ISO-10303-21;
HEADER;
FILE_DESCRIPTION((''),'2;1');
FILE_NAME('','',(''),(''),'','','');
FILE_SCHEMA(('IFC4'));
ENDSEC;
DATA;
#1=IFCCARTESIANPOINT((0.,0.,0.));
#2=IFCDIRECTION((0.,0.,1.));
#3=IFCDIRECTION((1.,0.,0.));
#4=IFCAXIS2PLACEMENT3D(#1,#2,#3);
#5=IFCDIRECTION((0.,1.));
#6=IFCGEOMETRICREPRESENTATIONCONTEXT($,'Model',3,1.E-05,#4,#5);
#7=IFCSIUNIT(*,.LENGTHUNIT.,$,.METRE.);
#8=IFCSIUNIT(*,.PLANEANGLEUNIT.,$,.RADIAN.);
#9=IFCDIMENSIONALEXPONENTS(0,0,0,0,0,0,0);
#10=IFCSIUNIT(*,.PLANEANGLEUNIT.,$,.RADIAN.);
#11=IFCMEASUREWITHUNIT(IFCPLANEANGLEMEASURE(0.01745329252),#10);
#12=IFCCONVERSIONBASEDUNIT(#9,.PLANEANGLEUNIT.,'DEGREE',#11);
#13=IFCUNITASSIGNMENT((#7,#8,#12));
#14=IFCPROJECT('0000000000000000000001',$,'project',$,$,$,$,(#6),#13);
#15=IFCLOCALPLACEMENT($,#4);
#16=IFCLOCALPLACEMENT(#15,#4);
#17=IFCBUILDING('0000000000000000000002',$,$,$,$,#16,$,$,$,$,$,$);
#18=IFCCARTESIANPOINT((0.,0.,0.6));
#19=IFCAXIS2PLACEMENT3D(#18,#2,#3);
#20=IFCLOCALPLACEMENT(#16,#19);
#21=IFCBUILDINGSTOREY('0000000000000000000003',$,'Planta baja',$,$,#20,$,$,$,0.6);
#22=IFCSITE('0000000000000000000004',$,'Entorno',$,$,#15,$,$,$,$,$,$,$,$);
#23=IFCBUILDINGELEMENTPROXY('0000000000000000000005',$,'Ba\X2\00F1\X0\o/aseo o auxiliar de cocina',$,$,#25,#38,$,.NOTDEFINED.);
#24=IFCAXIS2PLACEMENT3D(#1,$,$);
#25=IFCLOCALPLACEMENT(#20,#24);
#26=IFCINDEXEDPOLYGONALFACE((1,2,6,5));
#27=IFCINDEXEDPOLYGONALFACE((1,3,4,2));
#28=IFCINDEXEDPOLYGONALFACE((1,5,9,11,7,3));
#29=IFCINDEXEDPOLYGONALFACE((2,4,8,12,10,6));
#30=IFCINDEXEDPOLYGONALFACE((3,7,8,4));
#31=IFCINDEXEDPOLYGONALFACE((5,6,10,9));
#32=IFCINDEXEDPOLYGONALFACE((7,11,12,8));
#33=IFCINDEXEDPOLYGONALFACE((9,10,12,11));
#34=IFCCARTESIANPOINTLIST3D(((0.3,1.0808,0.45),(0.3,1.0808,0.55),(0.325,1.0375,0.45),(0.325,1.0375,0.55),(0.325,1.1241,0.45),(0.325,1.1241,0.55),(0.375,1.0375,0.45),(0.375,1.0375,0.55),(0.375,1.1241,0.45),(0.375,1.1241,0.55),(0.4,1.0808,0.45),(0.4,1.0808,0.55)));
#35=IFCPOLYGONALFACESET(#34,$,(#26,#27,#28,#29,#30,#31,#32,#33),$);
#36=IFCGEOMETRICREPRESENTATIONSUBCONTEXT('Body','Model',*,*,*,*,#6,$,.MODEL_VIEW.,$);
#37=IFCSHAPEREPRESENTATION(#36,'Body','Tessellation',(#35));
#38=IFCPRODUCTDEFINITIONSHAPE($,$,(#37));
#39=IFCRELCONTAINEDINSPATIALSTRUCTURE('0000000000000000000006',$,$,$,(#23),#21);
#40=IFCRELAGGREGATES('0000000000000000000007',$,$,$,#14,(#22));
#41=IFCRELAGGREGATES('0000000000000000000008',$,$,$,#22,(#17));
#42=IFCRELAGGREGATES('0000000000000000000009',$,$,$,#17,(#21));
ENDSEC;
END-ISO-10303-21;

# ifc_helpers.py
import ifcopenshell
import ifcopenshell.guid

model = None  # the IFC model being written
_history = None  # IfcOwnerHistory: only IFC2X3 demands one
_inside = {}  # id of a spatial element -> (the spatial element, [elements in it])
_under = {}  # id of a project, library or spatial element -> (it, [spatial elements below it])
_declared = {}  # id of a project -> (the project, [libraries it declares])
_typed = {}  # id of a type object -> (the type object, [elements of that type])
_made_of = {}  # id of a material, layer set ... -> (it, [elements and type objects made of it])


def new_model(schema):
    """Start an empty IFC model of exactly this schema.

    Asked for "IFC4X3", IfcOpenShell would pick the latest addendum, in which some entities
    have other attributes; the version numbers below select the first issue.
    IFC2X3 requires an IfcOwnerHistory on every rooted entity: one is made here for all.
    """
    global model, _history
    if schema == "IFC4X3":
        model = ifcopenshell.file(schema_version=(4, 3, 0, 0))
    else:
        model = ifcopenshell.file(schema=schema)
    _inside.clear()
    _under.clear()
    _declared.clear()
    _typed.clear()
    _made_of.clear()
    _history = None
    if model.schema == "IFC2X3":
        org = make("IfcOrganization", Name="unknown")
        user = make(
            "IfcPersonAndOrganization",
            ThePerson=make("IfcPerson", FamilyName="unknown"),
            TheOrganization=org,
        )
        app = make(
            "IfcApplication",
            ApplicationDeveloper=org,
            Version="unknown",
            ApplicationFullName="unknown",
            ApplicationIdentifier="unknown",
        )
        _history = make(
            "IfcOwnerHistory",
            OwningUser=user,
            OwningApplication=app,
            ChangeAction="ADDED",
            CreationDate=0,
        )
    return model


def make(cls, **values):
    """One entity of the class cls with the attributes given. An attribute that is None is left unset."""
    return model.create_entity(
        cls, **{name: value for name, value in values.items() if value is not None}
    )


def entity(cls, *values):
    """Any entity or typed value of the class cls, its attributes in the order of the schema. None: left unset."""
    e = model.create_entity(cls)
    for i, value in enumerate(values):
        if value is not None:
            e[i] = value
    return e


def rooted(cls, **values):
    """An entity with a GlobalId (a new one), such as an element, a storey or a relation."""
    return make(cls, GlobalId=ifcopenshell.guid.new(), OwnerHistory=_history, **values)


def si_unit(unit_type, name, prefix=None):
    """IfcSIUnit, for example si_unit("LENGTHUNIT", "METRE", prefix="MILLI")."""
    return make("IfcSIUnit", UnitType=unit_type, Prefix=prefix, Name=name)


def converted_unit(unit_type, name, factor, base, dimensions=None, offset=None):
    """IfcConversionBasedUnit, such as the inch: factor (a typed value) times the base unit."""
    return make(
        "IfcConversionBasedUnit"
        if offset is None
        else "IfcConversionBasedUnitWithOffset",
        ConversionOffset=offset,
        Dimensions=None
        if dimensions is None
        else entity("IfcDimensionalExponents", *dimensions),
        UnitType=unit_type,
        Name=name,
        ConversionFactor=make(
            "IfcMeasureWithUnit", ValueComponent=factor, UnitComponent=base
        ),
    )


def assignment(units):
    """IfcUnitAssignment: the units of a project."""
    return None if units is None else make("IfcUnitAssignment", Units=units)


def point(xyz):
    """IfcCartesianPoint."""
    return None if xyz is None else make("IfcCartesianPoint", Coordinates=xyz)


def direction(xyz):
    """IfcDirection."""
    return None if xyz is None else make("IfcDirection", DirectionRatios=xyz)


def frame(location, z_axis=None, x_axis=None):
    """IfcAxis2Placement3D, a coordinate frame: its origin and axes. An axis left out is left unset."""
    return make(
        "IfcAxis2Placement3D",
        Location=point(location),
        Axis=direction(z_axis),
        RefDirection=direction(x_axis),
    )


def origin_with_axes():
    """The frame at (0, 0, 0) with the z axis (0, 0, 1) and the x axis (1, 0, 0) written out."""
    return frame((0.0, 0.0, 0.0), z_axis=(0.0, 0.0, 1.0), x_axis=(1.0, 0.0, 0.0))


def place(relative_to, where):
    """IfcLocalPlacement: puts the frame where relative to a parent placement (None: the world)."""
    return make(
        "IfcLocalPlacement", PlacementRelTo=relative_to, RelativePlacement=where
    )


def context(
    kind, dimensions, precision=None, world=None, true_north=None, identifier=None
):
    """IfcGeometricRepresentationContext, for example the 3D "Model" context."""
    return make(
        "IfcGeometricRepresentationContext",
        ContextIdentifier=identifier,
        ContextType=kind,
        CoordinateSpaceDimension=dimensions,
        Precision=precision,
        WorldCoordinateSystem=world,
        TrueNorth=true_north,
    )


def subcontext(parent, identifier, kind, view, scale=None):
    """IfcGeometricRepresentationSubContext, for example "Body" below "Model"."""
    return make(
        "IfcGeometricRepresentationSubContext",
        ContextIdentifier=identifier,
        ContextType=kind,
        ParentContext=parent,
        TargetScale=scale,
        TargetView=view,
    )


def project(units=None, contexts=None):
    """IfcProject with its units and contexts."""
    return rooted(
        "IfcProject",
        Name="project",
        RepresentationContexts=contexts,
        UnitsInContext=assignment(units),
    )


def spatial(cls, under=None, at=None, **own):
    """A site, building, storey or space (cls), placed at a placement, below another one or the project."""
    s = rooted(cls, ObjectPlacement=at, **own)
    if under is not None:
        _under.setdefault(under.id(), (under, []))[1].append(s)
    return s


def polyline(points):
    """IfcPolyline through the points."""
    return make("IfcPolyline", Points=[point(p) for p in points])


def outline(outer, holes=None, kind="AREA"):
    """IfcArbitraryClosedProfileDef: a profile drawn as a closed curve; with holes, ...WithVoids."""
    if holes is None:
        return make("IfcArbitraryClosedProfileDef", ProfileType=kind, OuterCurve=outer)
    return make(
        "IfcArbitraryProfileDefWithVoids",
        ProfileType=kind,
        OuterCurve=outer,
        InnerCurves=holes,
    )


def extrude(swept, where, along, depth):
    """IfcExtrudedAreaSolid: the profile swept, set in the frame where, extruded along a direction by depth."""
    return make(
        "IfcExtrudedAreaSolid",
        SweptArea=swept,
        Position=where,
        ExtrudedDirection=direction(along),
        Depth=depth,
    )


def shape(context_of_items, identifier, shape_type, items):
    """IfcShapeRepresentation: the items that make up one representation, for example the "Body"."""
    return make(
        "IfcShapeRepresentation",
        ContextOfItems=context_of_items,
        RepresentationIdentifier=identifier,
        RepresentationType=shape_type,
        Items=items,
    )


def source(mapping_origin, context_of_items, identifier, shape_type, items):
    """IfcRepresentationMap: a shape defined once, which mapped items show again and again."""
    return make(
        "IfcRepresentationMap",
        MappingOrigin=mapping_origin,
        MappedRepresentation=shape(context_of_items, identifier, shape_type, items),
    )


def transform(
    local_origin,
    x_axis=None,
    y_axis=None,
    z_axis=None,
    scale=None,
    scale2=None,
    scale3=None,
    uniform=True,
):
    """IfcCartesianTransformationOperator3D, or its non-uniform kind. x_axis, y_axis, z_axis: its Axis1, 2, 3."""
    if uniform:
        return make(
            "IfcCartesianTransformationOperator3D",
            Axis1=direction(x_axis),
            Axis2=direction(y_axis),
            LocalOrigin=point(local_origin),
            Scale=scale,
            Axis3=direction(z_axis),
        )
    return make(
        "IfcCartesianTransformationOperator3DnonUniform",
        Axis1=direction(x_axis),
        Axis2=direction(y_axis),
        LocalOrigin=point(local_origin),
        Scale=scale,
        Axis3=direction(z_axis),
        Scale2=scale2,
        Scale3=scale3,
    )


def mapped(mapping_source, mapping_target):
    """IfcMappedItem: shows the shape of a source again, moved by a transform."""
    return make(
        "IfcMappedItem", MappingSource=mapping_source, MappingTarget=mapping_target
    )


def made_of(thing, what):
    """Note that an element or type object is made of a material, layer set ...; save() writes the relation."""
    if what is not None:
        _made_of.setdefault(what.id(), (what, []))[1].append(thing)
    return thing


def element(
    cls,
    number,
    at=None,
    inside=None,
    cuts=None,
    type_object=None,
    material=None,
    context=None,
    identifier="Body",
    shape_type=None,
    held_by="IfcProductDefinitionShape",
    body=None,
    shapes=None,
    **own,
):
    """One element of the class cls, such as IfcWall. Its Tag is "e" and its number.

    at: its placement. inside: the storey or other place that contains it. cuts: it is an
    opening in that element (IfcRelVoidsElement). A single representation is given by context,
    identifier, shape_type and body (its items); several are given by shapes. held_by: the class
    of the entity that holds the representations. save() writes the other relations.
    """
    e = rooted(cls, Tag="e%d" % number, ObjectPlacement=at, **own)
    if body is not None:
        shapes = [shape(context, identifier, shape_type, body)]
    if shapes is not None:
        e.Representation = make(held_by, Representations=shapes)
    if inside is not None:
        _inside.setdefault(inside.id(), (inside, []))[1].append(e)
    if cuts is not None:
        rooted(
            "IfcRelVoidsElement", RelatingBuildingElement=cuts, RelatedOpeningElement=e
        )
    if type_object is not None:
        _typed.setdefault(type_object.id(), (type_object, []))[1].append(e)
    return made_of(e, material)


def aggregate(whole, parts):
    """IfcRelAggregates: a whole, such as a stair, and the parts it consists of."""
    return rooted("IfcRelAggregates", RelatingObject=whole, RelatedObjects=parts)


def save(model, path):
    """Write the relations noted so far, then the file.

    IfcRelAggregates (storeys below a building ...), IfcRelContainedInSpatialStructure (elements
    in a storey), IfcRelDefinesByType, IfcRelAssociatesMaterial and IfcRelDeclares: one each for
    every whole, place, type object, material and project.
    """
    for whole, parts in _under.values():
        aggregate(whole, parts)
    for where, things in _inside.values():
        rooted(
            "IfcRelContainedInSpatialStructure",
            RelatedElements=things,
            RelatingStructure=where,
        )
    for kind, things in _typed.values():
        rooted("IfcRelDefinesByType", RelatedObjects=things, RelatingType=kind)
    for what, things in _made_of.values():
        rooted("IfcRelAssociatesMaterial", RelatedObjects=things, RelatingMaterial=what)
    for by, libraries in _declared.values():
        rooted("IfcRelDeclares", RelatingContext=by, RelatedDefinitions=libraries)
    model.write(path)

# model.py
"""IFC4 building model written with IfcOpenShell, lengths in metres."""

from ifc_helpers import new_model, entity, si_unit, converted_unit, direction, frame, origin_with_axes, place, context, subcontext, project, spatial, polyline, outline, extrude, source, transform, mapped, element, save


model = new_model("IFC4")

# Units and contexts
model_context = context("Model", 3, precision=1e-05, world=origin_with_axes(), true_north=direction((0.0, 1.0)))
body_context = subcontext(model_context, "Body", "Model", "MODEL_VIEW")
ifc_project = project(units=[si_unit("LENGTHUNIT", "METRE"), si_unit("PLANEANGLEUNIT", "RADIAN"), converted_unit("PLANEANGLEUNIT", "DEGREE", entity("IfcPlaneAngleMeasure", 0.01745329252), si_unit("PLANEANGLEUNIT", "RADIAN"), dimensions=[0, 0, 0, 0, 0, 0, 0])], contexts=[model_context])

# Site, building, storey
site_placement = place(None, origin_with_axes())
site = spatial("IfcSite", under=ifc_project, at=site_placement, Name="Entorno")
building_placement = place(site_placement, origin_with_axes())
building = spatial("IfcBuilding", under=site, at=building_placement)
storey_placement = place(building_placement, frame((0.0, 0.0, 0.6), z_axis=(0.0, 0.0, 1.0), x_axis=(1.0, 0.0, 0.0)))
storey = spatial("IfcBuildingStorey", under=building, at=storey_placement, Name="Planta baja", Elevation=0.6)

# Building element proxy
shared_shape_1 = source(origin_with_axes(), body_context, "Body", "SolidModel", [
    extrude(outline(polyline([(0.05, 0.0), (0.025, 0.0433), (-0.025, 0.0433), (-0.05, 0.0), (-0.025, -0.0433), (0.025, -0.0433), (0.05, 0.0)])), frame((0.0, 0.0, -0.05), z_axis=(0.0, 0.0, 1.0), x_axis=(1.0, 0.0, 0.0)), (0.0, 0.0, 1.0), 0.1),
])
proxy_1_placement = place(storey_placement, frame((0.0, 0.0, -0.6), z_axis=(0.0, 0.0, 1.0), x_axis=(1.0, 0.0, 0.0)))
element("IfcBuildingElementProxy", 1, at=proxy_1_placement, inside=storey, Name="Baño/aseo o auxiliar de cocina", PredefinedType="NOTDEFINED", context=body_context, shape_type="Brep", body=[
    mapped(shared_shape_1, transform((0.35, 1.0808, 1.1), x_axis=(1.0, 0.0, 0.0), y_axis=(0.0, 1.0, 0.0), z_axis=(0.0, 0.0, 1.0))),
])

save(model, "model.ifc")
